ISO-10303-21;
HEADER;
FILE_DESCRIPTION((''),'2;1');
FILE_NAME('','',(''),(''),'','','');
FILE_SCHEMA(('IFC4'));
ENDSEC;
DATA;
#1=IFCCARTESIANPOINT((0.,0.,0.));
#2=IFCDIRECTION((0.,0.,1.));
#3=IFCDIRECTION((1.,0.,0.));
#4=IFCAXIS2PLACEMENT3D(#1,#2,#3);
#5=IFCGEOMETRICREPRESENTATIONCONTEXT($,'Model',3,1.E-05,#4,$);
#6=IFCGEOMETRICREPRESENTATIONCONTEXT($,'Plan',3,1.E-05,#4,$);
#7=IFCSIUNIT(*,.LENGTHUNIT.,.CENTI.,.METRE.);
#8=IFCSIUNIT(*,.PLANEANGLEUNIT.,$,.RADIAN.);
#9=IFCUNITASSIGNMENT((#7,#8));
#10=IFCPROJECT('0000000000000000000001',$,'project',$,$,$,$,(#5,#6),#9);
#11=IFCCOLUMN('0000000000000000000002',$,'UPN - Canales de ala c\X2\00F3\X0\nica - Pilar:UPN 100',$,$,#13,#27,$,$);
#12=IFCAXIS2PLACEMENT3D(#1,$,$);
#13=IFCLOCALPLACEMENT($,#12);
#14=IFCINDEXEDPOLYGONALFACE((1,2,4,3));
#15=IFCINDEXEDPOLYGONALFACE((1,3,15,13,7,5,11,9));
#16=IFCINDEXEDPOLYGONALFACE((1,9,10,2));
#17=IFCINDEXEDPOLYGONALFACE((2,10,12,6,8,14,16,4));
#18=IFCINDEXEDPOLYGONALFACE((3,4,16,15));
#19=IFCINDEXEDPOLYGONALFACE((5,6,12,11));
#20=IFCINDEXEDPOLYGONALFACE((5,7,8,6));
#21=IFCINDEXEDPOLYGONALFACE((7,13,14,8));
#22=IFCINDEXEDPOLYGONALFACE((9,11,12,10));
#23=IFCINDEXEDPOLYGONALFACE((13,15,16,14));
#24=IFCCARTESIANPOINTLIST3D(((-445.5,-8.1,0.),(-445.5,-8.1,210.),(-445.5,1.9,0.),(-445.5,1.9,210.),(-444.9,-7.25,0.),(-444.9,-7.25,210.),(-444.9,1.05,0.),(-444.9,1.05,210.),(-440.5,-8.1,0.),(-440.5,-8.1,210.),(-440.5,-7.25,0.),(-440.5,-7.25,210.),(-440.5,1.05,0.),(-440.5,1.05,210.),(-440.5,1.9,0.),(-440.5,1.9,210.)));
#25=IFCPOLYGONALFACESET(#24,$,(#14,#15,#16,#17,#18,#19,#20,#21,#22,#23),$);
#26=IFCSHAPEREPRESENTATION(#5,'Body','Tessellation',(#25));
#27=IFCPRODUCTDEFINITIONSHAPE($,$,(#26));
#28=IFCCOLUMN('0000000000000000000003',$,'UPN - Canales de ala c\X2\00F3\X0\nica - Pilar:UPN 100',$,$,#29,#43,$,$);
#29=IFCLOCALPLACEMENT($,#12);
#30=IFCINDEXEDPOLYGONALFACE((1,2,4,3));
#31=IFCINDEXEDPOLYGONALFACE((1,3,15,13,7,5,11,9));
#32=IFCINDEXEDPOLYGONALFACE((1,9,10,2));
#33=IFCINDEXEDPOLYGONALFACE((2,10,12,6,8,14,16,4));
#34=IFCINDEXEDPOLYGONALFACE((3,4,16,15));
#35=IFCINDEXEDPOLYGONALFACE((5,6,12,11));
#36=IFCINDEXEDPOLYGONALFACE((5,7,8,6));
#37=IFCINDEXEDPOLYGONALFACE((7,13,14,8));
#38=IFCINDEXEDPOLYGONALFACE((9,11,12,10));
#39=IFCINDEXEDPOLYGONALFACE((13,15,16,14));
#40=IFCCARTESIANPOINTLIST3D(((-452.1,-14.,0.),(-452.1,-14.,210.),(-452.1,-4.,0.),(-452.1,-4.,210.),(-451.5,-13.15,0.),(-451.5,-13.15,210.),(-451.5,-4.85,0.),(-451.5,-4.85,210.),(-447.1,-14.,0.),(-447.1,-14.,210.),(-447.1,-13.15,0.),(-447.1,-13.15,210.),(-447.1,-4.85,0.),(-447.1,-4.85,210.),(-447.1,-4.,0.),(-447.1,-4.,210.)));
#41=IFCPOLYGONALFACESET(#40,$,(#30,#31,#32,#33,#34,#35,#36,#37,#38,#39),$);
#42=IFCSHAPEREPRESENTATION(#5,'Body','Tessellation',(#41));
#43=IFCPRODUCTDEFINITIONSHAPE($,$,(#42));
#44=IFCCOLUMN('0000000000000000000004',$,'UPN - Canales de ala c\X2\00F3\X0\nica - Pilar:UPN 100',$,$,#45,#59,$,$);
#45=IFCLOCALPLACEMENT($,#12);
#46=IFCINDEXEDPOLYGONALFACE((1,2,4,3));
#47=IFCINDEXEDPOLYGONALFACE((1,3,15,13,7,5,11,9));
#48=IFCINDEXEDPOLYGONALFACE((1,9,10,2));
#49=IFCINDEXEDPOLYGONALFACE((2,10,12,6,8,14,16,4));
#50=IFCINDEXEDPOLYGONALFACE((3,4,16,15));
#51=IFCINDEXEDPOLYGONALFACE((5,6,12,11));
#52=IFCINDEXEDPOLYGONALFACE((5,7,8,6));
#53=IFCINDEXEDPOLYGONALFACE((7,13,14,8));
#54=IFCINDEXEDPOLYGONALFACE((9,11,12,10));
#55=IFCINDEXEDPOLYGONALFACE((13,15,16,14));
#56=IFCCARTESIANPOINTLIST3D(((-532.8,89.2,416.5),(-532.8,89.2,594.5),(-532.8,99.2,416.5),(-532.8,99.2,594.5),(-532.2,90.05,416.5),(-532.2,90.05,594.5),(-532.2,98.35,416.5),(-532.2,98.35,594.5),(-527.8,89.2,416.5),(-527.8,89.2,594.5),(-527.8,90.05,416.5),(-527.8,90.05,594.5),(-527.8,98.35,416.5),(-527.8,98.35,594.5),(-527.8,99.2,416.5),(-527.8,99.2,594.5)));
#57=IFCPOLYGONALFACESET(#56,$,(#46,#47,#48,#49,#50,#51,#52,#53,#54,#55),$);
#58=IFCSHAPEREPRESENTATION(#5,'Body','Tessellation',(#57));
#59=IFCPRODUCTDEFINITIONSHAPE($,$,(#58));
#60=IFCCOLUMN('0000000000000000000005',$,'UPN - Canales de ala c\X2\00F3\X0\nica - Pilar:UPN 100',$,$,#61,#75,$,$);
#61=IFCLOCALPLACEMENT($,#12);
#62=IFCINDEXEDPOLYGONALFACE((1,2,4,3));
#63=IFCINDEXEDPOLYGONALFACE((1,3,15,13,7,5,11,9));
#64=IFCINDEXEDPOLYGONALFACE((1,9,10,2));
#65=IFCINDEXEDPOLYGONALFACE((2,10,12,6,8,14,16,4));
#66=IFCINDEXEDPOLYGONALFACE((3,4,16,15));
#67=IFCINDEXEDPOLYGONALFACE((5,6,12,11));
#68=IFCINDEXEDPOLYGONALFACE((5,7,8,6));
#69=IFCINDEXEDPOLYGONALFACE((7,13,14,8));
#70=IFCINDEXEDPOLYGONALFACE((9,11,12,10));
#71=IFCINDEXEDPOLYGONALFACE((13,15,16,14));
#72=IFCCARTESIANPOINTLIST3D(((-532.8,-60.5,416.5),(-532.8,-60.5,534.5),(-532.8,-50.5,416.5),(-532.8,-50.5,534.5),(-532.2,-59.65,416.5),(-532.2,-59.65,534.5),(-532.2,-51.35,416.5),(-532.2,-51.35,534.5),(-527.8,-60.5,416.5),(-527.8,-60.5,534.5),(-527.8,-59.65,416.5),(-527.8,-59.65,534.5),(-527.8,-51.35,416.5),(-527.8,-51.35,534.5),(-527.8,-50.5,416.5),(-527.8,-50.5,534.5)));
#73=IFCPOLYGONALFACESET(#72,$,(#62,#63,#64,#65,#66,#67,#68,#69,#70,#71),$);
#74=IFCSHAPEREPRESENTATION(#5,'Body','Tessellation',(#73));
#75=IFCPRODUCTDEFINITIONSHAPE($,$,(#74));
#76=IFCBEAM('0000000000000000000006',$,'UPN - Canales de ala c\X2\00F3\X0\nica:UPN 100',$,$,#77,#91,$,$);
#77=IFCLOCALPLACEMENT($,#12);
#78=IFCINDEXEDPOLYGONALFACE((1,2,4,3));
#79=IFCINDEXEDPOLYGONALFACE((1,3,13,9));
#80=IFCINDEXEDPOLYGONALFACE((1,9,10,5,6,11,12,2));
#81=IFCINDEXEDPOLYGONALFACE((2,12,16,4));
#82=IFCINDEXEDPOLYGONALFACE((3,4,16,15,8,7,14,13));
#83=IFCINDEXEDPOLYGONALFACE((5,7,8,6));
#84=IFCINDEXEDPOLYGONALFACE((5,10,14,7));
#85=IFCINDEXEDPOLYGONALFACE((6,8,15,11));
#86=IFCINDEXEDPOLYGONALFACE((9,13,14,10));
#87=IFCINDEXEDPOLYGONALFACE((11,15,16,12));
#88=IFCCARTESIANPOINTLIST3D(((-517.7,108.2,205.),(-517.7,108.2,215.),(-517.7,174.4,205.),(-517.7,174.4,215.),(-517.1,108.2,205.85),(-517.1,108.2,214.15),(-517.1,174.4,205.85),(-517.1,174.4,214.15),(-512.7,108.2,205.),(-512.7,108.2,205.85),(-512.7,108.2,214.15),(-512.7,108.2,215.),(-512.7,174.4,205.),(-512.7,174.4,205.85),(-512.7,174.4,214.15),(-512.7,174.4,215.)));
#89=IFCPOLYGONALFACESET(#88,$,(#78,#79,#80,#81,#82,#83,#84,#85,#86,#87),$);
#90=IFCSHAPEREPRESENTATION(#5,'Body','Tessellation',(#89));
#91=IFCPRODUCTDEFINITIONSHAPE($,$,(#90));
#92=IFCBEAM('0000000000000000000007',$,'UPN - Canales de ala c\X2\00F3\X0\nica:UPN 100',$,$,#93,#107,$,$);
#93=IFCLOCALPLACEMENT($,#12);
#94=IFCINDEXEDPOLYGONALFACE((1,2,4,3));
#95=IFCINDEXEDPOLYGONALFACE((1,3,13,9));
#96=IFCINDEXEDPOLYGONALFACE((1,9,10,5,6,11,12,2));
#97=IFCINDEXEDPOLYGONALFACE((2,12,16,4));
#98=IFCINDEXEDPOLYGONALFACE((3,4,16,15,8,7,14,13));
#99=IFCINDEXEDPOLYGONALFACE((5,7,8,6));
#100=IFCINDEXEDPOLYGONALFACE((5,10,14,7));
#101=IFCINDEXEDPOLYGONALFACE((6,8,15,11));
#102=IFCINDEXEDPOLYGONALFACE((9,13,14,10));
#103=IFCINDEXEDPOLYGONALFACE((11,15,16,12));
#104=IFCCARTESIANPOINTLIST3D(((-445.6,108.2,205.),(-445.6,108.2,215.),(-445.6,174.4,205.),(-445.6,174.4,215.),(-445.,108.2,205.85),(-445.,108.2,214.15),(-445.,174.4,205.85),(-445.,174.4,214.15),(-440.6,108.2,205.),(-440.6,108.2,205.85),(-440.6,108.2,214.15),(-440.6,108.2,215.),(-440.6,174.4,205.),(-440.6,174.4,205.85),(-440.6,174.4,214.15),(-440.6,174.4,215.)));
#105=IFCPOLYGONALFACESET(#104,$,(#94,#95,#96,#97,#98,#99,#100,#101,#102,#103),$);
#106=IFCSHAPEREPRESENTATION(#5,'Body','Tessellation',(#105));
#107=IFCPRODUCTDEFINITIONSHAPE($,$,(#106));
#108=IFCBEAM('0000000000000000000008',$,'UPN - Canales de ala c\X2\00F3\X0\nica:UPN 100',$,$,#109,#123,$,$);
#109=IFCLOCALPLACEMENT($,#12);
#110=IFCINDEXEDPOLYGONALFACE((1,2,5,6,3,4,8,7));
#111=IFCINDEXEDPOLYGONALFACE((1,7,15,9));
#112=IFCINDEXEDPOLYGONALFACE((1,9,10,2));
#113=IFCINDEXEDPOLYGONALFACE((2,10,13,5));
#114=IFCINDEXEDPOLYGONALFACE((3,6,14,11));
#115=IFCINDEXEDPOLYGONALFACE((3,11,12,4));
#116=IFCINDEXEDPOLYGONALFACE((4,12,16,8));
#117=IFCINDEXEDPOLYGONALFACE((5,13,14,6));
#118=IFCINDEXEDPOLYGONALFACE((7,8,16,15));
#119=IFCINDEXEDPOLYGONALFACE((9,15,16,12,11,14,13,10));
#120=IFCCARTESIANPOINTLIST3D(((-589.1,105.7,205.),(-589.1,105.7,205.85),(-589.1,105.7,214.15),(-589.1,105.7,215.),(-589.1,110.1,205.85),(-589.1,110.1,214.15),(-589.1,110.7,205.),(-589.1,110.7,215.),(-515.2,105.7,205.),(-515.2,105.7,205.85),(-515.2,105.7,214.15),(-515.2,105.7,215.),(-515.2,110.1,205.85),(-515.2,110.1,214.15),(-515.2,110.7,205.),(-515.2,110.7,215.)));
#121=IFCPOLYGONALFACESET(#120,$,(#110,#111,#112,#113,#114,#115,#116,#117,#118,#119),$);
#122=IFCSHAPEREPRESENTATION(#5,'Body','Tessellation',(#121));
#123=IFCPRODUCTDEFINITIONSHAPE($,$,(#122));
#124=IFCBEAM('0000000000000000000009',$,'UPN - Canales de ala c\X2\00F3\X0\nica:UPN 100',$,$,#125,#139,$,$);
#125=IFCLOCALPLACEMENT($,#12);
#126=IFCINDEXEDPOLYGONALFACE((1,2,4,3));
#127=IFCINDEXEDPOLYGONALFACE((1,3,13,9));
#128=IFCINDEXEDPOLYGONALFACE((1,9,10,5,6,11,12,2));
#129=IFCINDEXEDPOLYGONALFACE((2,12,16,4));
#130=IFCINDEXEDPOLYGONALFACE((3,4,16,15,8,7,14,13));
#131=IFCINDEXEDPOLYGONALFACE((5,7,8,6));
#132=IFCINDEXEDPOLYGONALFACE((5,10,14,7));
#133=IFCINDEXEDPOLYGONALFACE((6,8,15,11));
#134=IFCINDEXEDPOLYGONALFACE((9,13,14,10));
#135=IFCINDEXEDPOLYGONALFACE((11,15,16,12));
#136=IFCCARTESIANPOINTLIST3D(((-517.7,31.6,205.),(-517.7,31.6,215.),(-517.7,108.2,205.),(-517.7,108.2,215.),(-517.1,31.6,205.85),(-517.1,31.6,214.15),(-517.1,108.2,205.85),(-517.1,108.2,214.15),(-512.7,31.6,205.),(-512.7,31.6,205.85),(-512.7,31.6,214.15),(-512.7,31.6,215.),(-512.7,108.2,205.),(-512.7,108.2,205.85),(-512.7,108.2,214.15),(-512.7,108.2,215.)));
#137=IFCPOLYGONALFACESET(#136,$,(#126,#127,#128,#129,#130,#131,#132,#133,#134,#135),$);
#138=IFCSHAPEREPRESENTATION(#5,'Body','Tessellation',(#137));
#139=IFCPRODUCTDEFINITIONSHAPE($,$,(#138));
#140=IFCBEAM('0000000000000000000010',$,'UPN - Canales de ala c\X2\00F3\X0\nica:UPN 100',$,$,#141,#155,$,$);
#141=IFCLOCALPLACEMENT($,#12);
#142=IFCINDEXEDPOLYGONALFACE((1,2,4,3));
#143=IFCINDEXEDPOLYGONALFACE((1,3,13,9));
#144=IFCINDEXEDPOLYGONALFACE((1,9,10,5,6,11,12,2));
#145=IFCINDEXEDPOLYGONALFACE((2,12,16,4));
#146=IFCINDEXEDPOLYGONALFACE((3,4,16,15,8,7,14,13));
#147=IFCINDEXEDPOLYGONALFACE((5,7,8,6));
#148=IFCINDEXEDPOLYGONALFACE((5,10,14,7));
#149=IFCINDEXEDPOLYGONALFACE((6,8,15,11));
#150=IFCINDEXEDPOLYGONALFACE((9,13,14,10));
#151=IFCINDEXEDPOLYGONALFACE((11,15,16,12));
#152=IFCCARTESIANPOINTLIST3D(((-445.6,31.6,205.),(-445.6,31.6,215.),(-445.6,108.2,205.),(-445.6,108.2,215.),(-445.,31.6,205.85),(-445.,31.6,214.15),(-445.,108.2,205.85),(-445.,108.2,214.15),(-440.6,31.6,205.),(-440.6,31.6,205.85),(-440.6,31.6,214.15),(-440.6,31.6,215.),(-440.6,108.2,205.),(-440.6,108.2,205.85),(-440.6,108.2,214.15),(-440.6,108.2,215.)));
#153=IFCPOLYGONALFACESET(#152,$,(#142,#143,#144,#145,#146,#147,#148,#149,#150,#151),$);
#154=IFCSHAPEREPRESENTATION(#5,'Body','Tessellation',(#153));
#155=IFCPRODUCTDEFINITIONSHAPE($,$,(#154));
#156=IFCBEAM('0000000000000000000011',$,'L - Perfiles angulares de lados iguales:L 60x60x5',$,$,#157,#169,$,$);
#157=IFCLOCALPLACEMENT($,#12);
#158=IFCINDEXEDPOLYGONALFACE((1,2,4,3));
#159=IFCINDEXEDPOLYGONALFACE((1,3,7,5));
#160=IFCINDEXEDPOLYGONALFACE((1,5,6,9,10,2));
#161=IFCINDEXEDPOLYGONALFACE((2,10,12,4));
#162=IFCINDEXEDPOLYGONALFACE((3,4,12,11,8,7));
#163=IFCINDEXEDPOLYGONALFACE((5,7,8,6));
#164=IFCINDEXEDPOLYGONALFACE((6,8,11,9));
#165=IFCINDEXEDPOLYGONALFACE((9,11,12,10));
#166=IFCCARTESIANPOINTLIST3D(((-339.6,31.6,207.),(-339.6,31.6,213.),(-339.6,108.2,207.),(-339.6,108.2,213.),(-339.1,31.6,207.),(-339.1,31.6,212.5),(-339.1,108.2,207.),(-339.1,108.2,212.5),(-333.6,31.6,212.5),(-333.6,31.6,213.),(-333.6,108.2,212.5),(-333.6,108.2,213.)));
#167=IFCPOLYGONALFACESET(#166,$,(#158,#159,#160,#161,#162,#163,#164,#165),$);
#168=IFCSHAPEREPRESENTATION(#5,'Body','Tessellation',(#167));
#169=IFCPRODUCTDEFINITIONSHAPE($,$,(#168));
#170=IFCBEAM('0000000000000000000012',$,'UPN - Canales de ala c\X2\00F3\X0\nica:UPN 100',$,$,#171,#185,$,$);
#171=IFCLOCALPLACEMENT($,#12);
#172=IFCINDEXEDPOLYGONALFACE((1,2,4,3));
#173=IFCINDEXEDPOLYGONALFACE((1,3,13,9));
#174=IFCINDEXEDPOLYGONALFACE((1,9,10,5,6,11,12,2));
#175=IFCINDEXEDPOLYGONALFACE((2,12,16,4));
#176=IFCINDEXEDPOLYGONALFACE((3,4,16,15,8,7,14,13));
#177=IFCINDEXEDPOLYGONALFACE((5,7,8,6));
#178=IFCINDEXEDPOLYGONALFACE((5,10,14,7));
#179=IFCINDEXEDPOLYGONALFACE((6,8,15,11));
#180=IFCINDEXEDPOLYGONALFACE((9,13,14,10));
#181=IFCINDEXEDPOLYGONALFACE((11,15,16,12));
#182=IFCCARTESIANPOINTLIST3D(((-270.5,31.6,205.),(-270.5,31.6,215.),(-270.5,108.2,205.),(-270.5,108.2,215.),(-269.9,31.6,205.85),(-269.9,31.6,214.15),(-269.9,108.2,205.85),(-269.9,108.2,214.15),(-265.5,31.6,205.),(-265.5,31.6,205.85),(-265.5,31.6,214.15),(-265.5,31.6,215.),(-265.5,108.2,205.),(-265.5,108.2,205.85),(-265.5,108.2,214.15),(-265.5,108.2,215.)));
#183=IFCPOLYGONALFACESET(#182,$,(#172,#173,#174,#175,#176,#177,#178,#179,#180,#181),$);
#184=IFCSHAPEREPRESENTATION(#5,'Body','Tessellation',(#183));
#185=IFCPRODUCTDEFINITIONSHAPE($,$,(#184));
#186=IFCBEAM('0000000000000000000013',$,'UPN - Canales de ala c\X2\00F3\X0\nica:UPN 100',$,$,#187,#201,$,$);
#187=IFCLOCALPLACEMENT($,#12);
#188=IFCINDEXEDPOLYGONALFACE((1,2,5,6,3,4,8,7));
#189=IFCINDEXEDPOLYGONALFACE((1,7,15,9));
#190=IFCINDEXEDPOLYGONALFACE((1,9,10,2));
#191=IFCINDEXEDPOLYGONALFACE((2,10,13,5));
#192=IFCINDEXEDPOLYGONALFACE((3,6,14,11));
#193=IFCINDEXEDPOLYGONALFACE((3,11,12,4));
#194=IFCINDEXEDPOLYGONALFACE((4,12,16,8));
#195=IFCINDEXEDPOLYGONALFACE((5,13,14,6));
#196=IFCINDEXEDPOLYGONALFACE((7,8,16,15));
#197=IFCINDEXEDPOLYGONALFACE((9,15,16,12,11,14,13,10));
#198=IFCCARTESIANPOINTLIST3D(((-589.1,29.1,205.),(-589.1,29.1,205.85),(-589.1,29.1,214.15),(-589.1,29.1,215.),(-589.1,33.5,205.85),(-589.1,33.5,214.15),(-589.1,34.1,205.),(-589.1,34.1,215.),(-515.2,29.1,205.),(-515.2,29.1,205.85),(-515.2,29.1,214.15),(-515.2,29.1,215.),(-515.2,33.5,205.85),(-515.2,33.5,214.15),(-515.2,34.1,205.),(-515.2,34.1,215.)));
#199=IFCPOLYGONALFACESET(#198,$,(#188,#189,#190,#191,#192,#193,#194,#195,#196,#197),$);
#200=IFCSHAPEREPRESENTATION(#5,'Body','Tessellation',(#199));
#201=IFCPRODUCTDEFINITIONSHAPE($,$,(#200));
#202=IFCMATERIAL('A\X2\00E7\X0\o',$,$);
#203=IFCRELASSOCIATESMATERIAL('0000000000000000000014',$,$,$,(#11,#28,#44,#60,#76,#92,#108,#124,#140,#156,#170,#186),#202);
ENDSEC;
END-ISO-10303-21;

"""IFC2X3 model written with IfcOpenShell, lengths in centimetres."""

from ifc_helpers import new_model, si_unit, frame, frame_2d, origin_with_axes, origin_2d_with_axis, place, context, project, polyline, u_section, outline, extrude, material, element, save


model = new_model("IFC2X3")

# Units and contexts
model_context = context("Model", 3, precision=1e-05, world=origin_with_axes())
plan_context = context("Plan", 3, precision=1e-05, world=origin_with_axes())
ifc_project = project(units=[si_unit("LENGTHUNIT", "METRE", prefix="CENTI"), si_unit("PLANEANGLEUNIT", "RADIAN")], contexts=[model_context, plan_context])

# Columns
ifc_material = material(Name="Aço")
column_1_placement = place(None, frame((-443.0, -3.1, 0.0), z_axis=(0.0, 0.0, 1.0), x_axis=(1.0, 0.0, 0.0)))
element("IfcColumn", 1, at=column_1_placement, material=ifc_material, Name="UPN - Canales de ala cónica - Pilar:UPN 100", context=model_context, shape_type="SweptSolid", body=[
    extrude(u_section(Depth=10.0, FlangeWidth=5.0, WebThickness=0.6, FlangeThickness=0.85, FilletRadius=0.0, EdgeRadius=0.0, FlangeSlope=0.0, CentreOfGravityInX=0.0, at=frame_2d((0.0, 0.0), x_axis=(1.0, 0.0))), origin_with_axes(), (0.0, 0.0, 1.0), 210.0),
])
column_2_placement = place(None, frame((-449.6, -9.0, 0.0), z_axis=(0.0, 0.0, 1.0), x_axis=(1.0, 0.0, 0.0)))
element("IfcColumn", 2, at=column_2_placement, material=ifc_material, Name="UPN - Canales de ala cónica - Pilar:UPN 100", context=model_context, shape_type="SweptSolid", body=[
    extrude(u_section(Depth=10.0, FlangeWidth=5.0, WebThickness=0.6, FlangeThickness=0.85, FilletRadius=0.0, EdgeRadius=0.0, FlangeSlope=0.0, CentreOfGravityInX=0.0, at=origin_2d_with_axis()), origin_with_axes(), (0.0, 0.0, 1.0), 210.0),
])
column_3_placement = place(None, frame((-530.3, 94.2, 416.5), z_axis=(0.0, 0.0, 1.0), x_axis=(1.0, 0.0, 0.0)))
element("IfcColumn", 3, at=column_3_placement, material=ifc_material, Name="UPN - Canales de ala cónica - Pilar:UPN 100", context=model_context, shape_type="SweptSolid", body=[
    extrude(u_section(Depth=10.0, FlangeWidth=5.0, WebThickness=0.6, FlangeThickness=0.85, FilletRadius=0.0, EdgeRadius=0.0, FlangeSlope=0.0, CentreOfGravityInX=0.0, at=origin_2d_with_axis()), origin_with_axes(), (0.0, 0.0, 1.0), 178.0),
])
column_4_placement = place(None, frame((-530.3, -55.5, 416.5), z_axis=(0.0, 0.0, 1.0), x_axis=(1.0, 0.0, 0.0)))
element("IfcColumn", 4, at=column_4_placement, material=ifc_material, Name="UPN - Canales de ala cónica - Pilar:UPN 100", context=model_context, shape_type="SweptSolid", body=[
    extrude(u_section(Depth=10.0, FlangeWidth=5.0, WebThickness=0.6, FlangeThickness=0.85, FilletRadius=0.0, EdgeRadius=0.0, FlangeSlope=0.0, CentreOfGravityInX=0.0, at=origin_2d_with_axis()), origin_with_axes(), (0.0, 0.0, 1.0), 118.0),
])

# Beams
for number, where, z_axis, x_axis, name in (
    (5, (-515.2, 108.2, 210.0), (0.0, 1.0, 0.0), (1.0, 0.0, 0.0), "UPN - Canales de ala cónica:UPN 100"),
    (6, (-443.1, 108.2, 210.0), (0.0, 1.0, 0.0), (1.0, 0.0, 0.0), "UPN - Canales de ala cónica:UPN 100"),
):
    element("IfcBeam", number, at=place(None, frame(where, z_axis=z_axis, x_axis=x_axis)), material=ifc_material, Name=name, context=model_context, shape_type="SweptSolid", body=[
        extrude(u_section(Depth=10.0, FlangeWidth=5.0, WebThickness=0.6, FlangeThickness=0.85, FilletRadius=0.0, EdgeRadius=0.0, FlangeSlope=0.0, CentreOfGravityInX=0.0, at=origin_2d_with_axis()), origin_with_axes(), (0.0, 0.0, 1.0), 66.2),
    ])
beam_1_placement = place(None, frame((-515.2, 108.2, 210.0), z_axis=(-1.0, 0.0, 0.0), x_axis=(0.0, -1.0, 0.0)))
element("IfcBeam", 7, at=beam_1_placement, material=ifc_material, Name="UPN - Canales de ala cónica:UPN 100", context=model_context, shape_type="SweptSolid", body=[
    extrude(u_section(Depth=10.0, FlangeWidth=5.0, WebThickness=0.6, FlangeThickness=0.85, FilletRadius=0.0, EdgeRadius=0.0, FlangeSlope=0.0, CentreOfGravityInX=0.0, at=origin_2d_with_axis()), origin_with_axes(), (0.0, 0.0, 1.0), 73.9),
])
for number, where, z_axis, x_axis, name in (
    (8, (-515.2, 31.6, 210.0), (0.0, 1.0, 0.0), (1.0, 0.0, 0.0), "UPN - Canales de ala cónica:UPN 100"),
    (9, (-443.1, 31.6, 210.0), (0.0, 1.0, 0.0), (1.0, 0.0, 0.0), "UPN - Canales de ala cónica:UPN 100"),
):
    element("IfcBeam", number, at=place(None, frame(where, z_axis=z_axis, x_axis=x_axis)), material=ifc_material, Name=name, context=model_context, shape_type="SweptSolid", body=[
        extrude(u_section(Depth=10.0, FlangeWidth=5.0, WebThickness=0.6, FlangeThickness=0.85, FilletRadius=0.0, EdgeRadius=0.0, FlangeSlope=0.0, CentreOfGravityInX=0.0, at=origin_2d_with_axis()), origin_with_axes(), (0.0, 0.0, 1.0), 76.6),
    ])
beam_2_placement = place(None, frame((-336.6, 31.6, 210.0), z_axis=(0.0, 1.0, 0.0), x_axis=(-1.0, 0.0, 0.0)))
element("IfcBeam", 10, at=beam_2_placement, material=ifc_material, Name="L - Perfiles angulares de lados iguales:L 60x60x5", context=model_context, shape_type="SweptSolid", body=[
    extrude(outline(polyline([(3.0, -3.0), (3.0, 3.0), (-3.0, 3.0), (-3.0, 2.5), (2.5, 2.5), (2.5, -3.0), (3.0, -3.0)])), origin_with_axes(), (0.0, 0.0, 1.0), 76.6),
])
beam_3_placement = place(None, frame((-268.0, 31.6, 210.0), z_axis=(0.0, 1.0, 0.0), x_axis=(1.0, 0.0, 0.0)))
element("IfcBeam", 11, at=beam_3_placement, material=ifc_material, Name="UPN - Canales de ala cónica:UPN 100", context=model_context, shape_type="SweptSolid", body=[
    extrude(u_section(Depth=10.0, FlangeWidth=5.0, WebThickness=0.6, FlangeThickness=0.85, FilletRadius=0.0, EdgeRadius=0.0, FlangeSlope=0.0, CentreOfGravityInX=0.0, at=origin_2d_with_axis()), origin_with_axes(), (0.0, 0.0, 1.0), 76.6),
])
beam_4_placement = place(None, frame((-515.2, 31.6, 210.0), z_axis=(-1.0, 0.0, 0.0), x_axis=(0.0, -1.0, 0.0)))
element("IfcBeam", 12, at=beam_4_placement, material=ifc_material, Name="UPN - Canales de ala cónica:UPN 100", context=model_context, shape_type="SweptSolid", body=[
    extrude(u_section(Depth=10.0, FlangeWidth=5.0, WebThickness=0.6, FlangeThickness=0.85, FilletRadius=0.0, EdgeRadius=0.0, FlangeSlope=0.0, CentreOfGravityInX=0.0, at=frame_2d((0.0, 0.0), x_axis=(1.0, 0.0))), origin_with_axes(), (0.0, 0.0, 1.0), 73.9),
])

save(model, "model.ifc")
